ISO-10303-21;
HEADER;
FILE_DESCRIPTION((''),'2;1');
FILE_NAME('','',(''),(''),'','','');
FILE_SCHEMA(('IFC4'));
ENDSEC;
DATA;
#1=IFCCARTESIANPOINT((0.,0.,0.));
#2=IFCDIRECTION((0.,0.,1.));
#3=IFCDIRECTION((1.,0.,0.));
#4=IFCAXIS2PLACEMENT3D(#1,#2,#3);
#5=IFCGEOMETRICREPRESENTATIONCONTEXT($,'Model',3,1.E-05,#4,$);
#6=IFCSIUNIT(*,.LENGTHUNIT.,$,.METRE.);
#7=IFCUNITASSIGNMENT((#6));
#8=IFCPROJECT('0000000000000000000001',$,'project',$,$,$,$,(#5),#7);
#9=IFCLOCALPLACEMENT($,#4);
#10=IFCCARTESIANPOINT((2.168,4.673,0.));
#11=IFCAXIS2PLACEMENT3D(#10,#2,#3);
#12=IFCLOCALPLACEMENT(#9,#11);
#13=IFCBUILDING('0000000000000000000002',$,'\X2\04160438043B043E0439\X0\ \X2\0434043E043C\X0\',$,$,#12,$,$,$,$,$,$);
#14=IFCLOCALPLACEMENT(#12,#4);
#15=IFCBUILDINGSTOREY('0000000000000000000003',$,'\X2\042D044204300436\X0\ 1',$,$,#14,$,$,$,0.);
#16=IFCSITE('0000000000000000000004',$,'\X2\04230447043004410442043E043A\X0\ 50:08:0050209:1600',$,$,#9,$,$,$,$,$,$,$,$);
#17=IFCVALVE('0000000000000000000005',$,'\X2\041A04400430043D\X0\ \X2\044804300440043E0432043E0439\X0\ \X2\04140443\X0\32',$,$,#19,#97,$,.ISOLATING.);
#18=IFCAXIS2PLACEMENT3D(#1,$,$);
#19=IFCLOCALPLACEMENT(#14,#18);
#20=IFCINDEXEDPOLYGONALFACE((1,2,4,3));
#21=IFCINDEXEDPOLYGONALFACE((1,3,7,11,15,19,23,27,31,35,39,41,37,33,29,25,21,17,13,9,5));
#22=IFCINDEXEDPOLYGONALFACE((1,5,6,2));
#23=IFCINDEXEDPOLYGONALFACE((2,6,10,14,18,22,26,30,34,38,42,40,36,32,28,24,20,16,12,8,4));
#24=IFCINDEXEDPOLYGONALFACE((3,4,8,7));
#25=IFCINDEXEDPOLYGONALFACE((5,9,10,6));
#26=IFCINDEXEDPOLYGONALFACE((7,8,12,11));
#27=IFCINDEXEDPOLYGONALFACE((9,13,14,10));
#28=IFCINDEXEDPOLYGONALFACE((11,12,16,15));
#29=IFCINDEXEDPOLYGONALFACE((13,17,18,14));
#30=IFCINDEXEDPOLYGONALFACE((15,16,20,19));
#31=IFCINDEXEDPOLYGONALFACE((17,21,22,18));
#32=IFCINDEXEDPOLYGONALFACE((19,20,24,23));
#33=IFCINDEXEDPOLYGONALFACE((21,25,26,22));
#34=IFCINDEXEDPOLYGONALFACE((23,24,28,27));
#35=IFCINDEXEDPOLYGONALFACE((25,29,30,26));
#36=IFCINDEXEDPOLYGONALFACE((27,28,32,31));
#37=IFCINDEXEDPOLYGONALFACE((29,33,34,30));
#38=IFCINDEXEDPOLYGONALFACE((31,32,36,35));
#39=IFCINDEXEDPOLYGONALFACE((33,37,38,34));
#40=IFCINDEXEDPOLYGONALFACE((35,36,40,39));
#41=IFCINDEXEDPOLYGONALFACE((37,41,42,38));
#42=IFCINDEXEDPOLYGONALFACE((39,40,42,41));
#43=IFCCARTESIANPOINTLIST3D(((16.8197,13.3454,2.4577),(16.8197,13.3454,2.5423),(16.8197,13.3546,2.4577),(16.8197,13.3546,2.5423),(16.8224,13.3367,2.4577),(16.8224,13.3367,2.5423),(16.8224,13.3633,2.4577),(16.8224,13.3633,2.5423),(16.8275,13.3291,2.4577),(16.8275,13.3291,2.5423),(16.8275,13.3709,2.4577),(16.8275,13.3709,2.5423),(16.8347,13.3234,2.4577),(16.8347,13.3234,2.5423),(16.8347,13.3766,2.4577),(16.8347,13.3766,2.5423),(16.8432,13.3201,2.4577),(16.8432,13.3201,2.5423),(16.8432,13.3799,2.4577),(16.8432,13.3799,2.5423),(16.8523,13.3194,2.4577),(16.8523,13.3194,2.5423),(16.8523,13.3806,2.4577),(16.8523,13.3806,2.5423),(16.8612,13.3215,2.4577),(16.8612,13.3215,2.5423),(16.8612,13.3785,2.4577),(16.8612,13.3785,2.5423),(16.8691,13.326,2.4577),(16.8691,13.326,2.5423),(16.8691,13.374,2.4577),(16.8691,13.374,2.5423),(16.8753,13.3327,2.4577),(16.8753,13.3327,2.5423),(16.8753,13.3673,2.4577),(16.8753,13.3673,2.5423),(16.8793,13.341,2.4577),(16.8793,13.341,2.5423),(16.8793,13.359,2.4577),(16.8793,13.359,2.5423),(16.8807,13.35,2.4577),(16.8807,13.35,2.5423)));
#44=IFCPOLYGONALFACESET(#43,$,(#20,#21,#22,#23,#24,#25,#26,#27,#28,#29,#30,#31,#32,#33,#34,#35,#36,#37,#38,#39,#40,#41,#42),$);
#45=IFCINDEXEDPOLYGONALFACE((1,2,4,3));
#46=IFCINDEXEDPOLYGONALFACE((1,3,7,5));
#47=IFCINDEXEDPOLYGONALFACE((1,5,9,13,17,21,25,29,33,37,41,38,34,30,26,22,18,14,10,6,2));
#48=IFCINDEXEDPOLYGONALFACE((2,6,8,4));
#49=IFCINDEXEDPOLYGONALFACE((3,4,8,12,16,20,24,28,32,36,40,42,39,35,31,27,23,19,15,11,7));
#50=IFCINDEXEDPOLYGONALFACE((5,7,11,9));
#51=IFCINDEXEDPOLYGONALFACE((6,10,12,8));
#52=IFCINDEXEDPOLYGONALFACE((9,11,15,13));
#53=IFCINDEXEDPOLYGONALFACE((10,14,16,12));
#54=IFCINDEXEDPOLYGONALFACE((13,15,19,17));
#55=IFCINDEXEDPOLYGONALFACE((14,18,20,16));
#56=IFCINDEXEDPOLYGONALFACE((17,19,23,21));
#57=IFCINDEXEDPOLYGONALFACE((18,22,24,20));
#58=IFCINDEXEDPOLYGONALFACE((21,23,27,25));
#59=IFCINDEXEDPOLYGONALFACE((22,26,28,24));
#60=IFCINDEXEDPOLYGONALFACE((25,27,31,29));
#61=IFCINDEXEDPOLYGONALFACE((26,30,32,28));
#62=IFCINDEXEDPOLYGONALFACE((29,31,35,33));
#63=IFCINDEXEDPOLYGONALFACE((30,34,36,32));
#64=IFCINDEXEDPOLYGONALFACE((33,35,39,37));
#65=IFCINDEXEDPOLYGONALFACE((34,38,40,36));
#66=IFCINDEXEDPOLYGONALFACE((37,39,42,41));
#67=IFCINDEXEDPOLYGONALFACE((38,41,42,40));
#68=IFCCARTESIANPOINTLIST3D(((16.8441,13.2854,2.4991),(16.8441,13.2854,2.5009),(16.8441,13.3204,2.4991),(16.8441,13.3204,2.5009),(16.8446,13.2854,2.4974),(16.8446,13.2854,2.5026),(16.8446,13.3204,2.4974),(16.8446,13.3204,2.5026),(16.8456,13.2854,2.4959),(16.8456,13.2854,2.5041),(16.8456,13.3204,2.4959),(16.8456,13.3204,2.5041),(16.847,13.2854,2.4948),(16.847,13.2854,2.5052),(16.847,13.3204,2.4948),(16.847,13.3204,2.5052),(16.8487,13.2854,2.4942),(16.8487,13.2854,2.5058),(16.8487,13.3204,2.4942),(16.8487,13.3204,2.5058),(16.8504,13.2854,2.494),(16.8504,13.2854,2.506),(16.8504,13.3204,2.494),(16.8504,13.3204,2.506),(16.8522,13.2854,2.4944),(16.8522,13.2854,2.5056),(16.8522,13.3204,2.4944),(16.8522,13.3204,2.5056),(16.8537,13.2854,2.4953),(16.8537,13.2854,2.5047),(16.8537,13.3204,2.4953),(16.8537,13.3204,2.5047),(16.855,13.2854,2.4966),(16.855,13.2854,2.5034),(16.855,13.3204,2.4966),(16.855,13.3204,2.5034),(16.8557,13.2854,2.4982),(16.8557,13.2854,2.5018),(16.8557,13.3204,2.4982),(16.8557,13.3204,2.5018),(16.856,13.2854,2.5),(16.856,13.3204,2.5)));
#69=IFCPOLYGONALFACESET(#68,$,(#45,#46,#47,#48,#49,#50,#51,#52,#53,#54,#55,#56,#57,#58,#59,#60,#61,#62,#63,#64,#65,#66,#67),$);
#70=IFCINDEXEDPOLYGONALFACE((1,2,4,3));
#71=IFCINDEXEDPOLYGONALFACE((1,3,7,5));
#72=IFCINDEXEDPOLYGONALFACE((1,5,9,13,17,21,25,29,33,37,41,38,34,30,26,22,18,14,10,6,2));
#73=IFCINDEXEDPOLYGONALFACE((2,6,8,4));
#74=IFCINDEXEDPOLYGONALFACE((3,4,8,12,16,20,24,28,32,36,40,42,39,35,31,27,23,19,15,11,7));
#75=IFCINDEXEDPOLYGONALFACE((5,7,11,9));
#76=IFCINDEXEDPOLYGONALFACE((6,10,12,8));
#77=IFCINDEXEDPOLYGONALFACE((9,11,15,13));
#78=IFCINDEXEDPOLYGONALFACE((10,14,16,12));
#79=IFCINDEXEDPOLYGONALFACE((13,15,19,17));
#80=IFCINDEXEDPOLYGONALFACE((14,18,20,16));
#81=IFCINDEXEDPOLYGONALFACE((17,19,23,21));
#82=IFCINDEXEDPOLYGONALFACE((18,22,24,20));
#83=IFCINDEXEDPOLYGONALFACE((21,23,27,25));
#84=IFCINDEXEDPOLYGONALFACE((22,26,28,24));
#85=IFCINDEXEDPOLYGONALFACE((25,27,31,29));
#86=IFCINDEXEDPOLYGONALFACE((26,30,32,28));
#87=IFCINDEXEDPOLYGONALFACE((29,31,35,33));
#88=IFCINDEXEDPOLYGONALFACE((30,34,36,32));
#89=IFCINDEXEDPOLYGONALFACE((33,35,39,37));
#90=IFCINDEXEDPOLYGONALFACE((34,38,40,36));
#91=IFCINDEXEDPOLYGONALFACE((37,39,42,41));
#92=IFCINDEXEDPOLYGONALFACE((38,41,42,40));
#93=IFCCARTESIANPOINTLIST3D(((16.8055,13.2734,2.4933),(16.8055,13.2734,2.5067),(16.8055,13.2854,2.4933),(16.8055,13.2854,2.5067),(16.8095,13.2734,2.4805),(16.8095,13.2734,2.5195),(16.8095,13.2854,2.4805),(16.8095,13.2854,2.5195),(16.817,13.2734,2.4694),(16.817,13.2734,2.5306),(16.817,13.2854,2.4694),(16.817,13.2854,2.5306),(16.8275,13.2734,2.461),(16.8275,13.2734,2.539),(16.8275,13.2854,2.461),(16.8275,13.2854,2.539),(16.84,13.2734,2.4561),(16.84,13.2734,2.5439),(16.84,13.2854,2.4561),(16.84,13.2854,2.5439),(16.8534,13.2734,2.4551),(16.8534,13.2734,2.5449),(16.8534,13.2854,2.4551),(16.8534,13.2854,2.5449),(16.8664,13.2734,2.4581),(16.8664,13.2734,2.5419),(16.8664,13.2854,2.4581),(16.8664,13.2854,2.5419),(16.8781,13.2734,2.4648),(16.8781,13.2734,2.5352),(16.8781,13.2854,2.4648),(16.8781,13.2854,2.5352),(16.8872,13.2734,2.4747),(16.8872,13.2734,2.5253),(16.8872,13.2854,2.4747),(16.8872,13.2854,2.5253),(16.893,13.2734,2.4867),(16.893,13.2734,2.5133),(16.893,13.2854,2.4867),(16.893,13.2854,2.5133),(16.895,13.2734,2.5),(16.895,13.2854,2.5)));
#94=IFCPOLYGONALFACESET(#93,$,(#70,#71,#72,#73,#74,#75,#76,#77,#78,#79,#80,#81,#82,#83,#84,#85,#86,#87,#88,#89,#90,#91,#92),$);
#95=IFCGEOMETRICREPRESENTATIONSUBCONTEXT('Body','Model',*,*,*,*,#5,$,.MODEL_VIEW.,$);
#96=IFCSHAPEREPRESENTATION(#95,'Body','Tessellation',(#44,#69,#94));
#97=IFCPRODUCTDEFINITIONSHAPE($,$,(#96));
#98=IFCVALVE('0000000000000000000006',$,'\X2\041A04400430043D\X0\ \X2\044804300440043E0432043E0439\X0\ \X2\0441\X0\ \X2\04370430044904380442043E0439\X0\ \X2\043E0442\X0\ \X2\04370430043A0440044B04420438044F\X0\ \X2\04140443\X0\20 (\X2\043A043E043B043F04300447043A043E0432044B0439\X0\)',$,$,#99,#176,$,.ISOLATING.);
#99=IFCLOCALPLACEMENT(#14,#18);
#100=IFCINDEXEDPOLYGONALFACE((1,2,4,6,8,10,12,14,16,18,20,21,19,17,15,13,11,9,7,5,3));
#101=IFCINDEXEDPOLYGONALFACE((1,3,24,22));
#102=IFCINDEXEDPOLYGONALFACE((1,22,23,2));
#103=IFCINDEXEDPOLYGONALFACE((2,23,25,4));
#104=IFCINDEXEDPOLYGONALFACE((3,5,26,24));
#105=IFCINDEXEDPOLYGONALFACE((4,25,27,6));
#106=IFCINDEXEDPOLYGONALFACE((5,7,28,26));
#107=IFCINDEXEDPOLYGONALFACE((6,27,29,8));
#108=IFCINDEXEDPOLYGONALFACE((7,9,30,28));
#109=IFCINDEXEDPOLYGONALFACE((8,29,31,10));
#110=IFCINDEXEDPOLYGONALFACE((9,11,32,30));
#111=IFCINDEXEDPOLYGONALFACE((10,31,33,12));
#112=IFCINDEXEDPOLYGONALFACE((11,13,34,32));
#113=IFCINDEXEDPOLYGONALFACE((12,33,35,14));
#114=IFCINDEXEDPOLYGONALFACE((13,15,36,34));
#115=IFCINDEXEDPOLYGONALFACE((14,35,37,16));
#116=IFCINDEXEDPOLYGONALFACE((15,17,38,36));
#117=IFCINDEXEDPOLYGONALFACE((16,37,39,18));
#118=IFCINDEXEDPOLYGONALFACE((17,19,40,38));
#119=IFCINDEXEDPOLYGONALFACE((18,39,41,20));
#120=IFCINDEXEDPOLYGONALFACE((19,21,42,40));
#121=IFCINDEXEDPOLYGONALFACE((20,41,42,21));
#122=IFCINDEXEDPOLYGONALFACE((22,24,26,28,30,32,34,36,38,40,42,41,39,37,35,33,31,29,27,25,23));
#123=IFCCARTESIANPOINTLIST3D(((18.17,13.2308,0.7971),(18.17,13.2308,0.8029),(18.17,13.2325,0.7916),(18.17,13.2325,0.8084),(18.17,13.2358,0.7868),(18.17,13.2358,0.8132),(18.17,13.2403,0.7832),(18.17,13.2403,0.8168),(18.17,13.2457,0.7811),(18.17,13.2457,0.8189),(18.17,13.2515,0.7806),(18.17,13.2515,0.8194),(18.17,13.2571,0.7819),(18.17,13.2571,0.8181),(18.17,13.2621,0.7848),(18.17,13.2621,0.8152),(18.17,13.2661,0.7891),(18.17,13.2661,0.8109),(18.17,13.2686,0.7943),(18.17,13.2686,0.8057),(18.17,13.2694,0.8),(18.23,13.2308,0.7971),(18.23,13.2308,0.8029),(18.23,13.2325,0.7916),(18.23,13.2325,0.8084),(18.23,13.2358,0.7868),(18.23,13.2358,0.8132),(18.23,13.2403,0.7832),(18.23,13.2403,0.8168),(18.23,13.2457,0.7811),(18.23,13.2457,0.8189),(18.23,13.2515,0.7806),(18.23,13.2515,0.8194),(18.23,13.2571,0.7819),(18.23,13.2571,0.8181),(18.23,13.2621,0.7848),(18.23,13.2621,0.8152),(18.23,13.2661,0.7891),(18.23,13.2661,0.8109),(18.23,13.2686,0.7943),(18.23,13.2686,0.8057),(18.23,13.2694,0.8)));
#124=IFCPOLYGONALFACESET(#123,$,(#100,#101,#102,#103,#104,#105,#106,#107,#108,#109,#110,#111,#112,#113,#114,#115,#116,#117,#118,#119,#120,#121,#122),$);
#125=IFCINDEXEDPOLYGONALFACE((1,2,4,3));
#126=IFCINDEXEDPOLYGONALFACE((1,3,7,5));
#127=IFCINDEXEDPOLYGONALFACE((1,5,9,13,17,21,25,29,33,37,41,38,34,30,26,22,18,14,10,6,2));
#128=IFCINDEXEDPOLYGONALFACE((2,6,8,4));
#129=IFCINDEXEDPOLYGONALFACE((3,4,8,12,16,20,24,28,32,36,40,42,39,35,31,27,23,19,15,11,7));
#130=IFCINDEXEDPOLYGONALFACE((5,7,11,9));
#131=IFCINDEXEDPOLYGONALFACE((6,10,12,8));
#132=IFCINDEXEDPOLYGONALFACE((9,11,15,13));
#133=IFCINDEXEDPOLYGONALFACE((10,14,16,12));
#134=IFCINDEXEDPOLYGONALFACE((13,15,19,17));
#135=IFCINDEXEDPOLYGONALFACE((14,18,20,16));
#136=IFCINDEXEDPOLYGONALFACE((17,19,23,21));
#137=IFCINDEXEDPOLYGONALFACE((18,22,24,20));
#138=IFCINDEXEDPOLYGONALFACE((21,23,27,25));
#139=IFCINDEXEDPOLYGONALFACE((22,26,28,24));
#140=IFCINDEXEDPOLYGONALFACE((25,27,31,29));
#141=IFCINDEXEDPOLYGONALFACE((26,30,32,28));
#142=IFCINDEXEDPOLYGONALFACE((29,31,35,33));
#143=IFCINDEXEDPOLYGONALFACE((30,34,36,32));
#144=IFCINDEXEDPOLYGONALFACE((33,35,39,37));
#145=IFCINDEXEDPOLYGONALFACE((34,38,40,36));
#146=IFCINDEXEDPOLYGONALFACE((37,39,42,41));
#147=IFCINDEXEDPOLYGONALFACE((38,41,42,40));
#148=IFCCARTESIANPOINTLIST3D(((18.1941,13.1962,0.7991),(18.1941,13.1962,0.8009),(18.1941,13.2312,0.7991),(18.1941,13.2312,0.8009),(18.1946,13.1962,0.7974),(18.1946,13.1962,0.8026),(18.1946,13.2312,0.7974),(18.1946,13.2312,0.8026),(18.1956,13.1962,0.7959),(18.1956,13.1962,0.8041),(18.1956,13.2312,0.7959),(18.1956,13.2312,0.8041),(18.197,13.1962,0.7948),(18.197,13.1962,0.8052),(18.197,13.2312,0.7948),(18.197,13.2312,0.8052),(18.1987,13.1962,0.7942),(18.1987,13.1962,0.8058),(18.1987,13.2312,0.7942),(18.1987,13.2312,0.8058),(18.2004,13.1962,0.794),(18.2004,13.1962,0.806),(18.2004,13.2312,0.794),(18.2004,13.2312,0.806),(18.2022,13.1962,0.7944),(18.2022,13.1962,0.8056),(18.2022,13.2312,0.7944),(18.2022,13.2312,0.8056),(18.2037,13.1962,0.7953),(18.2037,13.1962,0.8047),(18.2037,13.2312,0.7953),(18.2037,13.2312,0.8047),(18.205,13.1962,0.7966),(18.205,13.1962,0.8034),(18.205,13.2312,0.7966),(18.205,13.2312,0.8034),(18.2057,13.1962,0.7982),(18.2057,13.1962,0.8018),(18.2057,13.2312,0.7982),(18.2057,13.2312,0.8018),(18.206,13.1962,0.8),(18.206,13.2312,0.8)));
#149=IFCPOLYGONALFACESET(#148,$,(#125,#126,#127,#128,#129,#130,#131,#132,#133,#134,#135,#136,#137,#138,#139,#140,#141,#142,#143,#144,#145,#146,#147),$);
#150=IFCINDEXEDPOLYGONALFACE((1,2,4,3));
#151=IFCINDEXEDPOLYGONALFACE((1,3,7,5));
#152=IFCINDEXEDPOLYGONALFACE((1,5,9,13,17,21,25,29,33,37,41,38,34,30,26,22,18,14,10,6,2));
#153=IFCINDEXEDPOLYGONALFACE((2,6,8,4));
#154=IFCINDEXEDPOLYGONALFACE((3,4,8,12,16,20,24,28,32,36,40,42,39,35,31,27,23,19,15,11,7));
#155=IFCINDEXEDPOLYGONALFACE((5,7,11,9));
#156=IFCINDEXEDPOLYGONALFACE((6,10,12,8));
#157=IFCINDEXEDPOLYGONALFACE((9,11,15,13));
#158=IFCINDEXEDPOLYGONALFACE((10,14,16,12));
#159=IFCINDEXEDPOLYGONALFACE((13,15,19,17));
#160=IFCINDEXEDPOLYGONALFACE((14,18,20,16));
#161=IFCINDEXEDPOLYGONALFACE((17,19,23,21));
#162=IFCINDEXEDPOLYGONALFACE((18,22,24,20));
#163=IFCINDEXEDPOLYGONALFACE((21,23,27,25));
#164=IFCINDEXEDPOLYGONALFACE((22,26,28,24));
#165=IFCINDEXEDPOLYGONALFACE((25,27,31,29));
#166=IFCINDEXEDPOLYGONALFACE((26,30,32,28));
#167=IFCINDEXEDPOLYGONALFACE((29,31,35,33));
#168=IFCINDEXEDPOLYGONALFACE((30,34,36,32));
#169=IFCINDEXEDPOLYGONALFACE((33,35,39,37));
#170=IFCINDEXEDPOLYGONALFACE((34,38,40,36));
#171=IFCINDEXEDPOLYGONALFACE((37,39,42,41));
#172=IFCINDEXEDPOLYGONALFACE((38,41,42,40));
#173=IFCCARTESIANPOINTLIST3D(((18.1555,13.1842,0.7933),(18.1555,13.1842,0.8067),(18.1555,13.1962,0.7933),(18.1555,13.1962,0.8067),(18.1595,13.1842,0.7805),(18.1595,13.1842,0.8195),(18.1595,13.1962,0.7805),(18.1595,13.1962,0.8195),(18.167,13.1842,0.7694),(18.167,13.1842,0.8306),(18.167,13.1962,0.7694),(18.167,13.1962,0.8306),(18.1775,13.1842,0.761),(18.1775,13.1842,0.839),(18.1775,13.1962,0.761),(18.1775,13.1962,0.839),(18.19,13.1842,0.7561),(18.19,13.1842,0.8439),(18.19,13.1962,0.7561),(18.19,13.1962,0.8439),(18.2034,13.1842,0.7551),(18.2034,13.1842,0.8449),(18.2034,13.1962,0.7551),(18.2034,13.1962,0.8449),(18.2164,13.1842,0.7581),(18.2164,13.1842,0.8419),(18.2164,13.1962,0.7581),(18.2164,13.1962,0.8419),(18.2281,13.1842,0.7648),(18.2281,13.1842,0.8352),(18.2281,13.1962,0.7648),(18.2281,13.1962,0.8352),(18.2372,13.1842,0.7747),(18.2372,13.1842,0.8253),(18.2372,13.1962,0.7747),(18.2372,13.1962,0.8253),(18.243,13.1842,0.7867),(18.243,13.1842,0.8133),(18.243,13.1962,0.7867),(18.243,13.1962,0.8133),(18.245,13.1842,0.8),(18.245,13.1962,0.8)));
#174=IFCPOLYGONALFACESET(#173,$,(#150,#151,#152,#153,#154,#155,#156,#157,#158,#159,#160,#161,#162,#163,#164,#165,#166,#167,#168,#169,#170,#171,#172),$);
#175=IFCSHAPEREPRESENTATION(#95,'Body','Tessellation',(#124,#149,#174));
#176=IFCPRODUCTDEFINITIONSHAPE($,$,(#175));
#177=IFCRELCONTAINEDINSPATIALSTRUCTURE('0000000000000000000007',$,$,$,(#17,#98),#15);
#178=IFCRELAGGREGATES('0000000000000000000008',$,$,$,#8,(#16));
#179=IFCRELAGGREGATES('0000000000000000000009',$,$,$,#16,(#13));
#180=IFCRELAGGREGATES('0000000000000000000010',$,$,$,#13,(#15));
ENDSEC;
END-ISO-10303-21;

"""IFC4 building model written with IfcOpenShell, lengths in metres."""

from ifc_helpers import new_model, si_unit, frame, origin_with_axes, origin_2d, place, context, subcontext, project, spatial, circle, extrude, element, save


model = new_model("IFC4")

# Units and contexts
model_context = context("Model", 3, precision=1e-05, world=origin_with_axes())
body_context = subcontext(model_context, "Body", "Model", "MODEL_VIEW")
ifc_project = project(units=[si_unit("LENGTHUNIT", "METRE")], contexts=[model_context])

# Site, building, storey
site_placement = place(None, origin_with_axes())
site = spatial("IfcSite", under=ifc_project, at=site_placement, Name="Участок 50:08:0050209:1600")
building_placement = place(site_placement, frame((2.168, 4.673, 0.0), z_axis=(0.0, 0.0, 1.0), x_axis=(1.0, 0.0, 0.0)))
building = spatial("IfcBuilding", under=site, at=building_placement, Name="Жилой дом")
storey_placement = place(building_placement, origin_with_axes())
storey = spatial("IfcBuildingStorey", under=building, at=storey_placement, Name="Этаж 1", Elevation=0.0)

# Valves
valve_1_placement = place(storey_placement, origin_with_axes())
element("IfcValve", 1, at=valve_1_placement, inside=storey, Name="Кран шаровой Ду32", PredefinedType="ISOLATING", context=body_context, shape_type="SweptSolid", body=[
    extrude(circle(Radius=0.0307, at=origin_2d()), frame((16.85, 13.35, 2.4577), z_axis=(0.0, 0.0, 1.0), x_axis=(1.0, 0.0, 0.0)), (0.0, 0.0, 1.0), 0.0846),
    extrude(circle(Radius=0.006, at=origin_2d()), frame((16.85, 13.3204, 2.5), z_axis=(0.0, -1.0, 0.0), x_axis=(1.0, 0.0, 0.0)), (0.0, 0.0, 1.0), 0.035),
    extrude(circle(Radius=0.045, at=origin_2d()), frame((16.85, 13.2854, 2.5), z_axis=(0.0, -1.0, 0.0), x_axis=(1.0, 0.0, 0.0)), (0.0, 0.0, 1.0), 0.012),
])
valve_2_placement = place(storey_placement, origin_with_axes())
element("IfcValve", 2, at=valve_2_placement, inside=storey, Name="Кран шаровой с защитой от закрытия Ду20 (колпачковый)", PredefinedType="ISOLATING", context=body_context, shape_type="SweptSolid", body=[
    extrude(circle(Radius=0.0194, at=origin_2d()), frame((18.17, 13.25, 0.8), z_axis=(1.0, 0.0, 0.0), x_axis=(0.0, 1.0, 0.0)), (0.0, 0.0, 1.0), 0.06),
    extrude(circle(Radius=0.006, at=origin_2d()), frame((18.2, 13.2312, 0.8), z_axis=(0.0, -1.0, 0.0), x_axis=(1.0, 0.0, 0.0)), (0.0, 0.0, 1.0), 0.035),
    extrude(circle(Radius=0.045, at=origin_2d()), frame((18.2, 13.1962, 0.8), z_axis=(0.0, -1.0, 0.0), x_axis=(1.0, 0.0, 0.0)), (0.0, 0.0, 1.0), 0.012),
])

save(model, "model.ifc")
